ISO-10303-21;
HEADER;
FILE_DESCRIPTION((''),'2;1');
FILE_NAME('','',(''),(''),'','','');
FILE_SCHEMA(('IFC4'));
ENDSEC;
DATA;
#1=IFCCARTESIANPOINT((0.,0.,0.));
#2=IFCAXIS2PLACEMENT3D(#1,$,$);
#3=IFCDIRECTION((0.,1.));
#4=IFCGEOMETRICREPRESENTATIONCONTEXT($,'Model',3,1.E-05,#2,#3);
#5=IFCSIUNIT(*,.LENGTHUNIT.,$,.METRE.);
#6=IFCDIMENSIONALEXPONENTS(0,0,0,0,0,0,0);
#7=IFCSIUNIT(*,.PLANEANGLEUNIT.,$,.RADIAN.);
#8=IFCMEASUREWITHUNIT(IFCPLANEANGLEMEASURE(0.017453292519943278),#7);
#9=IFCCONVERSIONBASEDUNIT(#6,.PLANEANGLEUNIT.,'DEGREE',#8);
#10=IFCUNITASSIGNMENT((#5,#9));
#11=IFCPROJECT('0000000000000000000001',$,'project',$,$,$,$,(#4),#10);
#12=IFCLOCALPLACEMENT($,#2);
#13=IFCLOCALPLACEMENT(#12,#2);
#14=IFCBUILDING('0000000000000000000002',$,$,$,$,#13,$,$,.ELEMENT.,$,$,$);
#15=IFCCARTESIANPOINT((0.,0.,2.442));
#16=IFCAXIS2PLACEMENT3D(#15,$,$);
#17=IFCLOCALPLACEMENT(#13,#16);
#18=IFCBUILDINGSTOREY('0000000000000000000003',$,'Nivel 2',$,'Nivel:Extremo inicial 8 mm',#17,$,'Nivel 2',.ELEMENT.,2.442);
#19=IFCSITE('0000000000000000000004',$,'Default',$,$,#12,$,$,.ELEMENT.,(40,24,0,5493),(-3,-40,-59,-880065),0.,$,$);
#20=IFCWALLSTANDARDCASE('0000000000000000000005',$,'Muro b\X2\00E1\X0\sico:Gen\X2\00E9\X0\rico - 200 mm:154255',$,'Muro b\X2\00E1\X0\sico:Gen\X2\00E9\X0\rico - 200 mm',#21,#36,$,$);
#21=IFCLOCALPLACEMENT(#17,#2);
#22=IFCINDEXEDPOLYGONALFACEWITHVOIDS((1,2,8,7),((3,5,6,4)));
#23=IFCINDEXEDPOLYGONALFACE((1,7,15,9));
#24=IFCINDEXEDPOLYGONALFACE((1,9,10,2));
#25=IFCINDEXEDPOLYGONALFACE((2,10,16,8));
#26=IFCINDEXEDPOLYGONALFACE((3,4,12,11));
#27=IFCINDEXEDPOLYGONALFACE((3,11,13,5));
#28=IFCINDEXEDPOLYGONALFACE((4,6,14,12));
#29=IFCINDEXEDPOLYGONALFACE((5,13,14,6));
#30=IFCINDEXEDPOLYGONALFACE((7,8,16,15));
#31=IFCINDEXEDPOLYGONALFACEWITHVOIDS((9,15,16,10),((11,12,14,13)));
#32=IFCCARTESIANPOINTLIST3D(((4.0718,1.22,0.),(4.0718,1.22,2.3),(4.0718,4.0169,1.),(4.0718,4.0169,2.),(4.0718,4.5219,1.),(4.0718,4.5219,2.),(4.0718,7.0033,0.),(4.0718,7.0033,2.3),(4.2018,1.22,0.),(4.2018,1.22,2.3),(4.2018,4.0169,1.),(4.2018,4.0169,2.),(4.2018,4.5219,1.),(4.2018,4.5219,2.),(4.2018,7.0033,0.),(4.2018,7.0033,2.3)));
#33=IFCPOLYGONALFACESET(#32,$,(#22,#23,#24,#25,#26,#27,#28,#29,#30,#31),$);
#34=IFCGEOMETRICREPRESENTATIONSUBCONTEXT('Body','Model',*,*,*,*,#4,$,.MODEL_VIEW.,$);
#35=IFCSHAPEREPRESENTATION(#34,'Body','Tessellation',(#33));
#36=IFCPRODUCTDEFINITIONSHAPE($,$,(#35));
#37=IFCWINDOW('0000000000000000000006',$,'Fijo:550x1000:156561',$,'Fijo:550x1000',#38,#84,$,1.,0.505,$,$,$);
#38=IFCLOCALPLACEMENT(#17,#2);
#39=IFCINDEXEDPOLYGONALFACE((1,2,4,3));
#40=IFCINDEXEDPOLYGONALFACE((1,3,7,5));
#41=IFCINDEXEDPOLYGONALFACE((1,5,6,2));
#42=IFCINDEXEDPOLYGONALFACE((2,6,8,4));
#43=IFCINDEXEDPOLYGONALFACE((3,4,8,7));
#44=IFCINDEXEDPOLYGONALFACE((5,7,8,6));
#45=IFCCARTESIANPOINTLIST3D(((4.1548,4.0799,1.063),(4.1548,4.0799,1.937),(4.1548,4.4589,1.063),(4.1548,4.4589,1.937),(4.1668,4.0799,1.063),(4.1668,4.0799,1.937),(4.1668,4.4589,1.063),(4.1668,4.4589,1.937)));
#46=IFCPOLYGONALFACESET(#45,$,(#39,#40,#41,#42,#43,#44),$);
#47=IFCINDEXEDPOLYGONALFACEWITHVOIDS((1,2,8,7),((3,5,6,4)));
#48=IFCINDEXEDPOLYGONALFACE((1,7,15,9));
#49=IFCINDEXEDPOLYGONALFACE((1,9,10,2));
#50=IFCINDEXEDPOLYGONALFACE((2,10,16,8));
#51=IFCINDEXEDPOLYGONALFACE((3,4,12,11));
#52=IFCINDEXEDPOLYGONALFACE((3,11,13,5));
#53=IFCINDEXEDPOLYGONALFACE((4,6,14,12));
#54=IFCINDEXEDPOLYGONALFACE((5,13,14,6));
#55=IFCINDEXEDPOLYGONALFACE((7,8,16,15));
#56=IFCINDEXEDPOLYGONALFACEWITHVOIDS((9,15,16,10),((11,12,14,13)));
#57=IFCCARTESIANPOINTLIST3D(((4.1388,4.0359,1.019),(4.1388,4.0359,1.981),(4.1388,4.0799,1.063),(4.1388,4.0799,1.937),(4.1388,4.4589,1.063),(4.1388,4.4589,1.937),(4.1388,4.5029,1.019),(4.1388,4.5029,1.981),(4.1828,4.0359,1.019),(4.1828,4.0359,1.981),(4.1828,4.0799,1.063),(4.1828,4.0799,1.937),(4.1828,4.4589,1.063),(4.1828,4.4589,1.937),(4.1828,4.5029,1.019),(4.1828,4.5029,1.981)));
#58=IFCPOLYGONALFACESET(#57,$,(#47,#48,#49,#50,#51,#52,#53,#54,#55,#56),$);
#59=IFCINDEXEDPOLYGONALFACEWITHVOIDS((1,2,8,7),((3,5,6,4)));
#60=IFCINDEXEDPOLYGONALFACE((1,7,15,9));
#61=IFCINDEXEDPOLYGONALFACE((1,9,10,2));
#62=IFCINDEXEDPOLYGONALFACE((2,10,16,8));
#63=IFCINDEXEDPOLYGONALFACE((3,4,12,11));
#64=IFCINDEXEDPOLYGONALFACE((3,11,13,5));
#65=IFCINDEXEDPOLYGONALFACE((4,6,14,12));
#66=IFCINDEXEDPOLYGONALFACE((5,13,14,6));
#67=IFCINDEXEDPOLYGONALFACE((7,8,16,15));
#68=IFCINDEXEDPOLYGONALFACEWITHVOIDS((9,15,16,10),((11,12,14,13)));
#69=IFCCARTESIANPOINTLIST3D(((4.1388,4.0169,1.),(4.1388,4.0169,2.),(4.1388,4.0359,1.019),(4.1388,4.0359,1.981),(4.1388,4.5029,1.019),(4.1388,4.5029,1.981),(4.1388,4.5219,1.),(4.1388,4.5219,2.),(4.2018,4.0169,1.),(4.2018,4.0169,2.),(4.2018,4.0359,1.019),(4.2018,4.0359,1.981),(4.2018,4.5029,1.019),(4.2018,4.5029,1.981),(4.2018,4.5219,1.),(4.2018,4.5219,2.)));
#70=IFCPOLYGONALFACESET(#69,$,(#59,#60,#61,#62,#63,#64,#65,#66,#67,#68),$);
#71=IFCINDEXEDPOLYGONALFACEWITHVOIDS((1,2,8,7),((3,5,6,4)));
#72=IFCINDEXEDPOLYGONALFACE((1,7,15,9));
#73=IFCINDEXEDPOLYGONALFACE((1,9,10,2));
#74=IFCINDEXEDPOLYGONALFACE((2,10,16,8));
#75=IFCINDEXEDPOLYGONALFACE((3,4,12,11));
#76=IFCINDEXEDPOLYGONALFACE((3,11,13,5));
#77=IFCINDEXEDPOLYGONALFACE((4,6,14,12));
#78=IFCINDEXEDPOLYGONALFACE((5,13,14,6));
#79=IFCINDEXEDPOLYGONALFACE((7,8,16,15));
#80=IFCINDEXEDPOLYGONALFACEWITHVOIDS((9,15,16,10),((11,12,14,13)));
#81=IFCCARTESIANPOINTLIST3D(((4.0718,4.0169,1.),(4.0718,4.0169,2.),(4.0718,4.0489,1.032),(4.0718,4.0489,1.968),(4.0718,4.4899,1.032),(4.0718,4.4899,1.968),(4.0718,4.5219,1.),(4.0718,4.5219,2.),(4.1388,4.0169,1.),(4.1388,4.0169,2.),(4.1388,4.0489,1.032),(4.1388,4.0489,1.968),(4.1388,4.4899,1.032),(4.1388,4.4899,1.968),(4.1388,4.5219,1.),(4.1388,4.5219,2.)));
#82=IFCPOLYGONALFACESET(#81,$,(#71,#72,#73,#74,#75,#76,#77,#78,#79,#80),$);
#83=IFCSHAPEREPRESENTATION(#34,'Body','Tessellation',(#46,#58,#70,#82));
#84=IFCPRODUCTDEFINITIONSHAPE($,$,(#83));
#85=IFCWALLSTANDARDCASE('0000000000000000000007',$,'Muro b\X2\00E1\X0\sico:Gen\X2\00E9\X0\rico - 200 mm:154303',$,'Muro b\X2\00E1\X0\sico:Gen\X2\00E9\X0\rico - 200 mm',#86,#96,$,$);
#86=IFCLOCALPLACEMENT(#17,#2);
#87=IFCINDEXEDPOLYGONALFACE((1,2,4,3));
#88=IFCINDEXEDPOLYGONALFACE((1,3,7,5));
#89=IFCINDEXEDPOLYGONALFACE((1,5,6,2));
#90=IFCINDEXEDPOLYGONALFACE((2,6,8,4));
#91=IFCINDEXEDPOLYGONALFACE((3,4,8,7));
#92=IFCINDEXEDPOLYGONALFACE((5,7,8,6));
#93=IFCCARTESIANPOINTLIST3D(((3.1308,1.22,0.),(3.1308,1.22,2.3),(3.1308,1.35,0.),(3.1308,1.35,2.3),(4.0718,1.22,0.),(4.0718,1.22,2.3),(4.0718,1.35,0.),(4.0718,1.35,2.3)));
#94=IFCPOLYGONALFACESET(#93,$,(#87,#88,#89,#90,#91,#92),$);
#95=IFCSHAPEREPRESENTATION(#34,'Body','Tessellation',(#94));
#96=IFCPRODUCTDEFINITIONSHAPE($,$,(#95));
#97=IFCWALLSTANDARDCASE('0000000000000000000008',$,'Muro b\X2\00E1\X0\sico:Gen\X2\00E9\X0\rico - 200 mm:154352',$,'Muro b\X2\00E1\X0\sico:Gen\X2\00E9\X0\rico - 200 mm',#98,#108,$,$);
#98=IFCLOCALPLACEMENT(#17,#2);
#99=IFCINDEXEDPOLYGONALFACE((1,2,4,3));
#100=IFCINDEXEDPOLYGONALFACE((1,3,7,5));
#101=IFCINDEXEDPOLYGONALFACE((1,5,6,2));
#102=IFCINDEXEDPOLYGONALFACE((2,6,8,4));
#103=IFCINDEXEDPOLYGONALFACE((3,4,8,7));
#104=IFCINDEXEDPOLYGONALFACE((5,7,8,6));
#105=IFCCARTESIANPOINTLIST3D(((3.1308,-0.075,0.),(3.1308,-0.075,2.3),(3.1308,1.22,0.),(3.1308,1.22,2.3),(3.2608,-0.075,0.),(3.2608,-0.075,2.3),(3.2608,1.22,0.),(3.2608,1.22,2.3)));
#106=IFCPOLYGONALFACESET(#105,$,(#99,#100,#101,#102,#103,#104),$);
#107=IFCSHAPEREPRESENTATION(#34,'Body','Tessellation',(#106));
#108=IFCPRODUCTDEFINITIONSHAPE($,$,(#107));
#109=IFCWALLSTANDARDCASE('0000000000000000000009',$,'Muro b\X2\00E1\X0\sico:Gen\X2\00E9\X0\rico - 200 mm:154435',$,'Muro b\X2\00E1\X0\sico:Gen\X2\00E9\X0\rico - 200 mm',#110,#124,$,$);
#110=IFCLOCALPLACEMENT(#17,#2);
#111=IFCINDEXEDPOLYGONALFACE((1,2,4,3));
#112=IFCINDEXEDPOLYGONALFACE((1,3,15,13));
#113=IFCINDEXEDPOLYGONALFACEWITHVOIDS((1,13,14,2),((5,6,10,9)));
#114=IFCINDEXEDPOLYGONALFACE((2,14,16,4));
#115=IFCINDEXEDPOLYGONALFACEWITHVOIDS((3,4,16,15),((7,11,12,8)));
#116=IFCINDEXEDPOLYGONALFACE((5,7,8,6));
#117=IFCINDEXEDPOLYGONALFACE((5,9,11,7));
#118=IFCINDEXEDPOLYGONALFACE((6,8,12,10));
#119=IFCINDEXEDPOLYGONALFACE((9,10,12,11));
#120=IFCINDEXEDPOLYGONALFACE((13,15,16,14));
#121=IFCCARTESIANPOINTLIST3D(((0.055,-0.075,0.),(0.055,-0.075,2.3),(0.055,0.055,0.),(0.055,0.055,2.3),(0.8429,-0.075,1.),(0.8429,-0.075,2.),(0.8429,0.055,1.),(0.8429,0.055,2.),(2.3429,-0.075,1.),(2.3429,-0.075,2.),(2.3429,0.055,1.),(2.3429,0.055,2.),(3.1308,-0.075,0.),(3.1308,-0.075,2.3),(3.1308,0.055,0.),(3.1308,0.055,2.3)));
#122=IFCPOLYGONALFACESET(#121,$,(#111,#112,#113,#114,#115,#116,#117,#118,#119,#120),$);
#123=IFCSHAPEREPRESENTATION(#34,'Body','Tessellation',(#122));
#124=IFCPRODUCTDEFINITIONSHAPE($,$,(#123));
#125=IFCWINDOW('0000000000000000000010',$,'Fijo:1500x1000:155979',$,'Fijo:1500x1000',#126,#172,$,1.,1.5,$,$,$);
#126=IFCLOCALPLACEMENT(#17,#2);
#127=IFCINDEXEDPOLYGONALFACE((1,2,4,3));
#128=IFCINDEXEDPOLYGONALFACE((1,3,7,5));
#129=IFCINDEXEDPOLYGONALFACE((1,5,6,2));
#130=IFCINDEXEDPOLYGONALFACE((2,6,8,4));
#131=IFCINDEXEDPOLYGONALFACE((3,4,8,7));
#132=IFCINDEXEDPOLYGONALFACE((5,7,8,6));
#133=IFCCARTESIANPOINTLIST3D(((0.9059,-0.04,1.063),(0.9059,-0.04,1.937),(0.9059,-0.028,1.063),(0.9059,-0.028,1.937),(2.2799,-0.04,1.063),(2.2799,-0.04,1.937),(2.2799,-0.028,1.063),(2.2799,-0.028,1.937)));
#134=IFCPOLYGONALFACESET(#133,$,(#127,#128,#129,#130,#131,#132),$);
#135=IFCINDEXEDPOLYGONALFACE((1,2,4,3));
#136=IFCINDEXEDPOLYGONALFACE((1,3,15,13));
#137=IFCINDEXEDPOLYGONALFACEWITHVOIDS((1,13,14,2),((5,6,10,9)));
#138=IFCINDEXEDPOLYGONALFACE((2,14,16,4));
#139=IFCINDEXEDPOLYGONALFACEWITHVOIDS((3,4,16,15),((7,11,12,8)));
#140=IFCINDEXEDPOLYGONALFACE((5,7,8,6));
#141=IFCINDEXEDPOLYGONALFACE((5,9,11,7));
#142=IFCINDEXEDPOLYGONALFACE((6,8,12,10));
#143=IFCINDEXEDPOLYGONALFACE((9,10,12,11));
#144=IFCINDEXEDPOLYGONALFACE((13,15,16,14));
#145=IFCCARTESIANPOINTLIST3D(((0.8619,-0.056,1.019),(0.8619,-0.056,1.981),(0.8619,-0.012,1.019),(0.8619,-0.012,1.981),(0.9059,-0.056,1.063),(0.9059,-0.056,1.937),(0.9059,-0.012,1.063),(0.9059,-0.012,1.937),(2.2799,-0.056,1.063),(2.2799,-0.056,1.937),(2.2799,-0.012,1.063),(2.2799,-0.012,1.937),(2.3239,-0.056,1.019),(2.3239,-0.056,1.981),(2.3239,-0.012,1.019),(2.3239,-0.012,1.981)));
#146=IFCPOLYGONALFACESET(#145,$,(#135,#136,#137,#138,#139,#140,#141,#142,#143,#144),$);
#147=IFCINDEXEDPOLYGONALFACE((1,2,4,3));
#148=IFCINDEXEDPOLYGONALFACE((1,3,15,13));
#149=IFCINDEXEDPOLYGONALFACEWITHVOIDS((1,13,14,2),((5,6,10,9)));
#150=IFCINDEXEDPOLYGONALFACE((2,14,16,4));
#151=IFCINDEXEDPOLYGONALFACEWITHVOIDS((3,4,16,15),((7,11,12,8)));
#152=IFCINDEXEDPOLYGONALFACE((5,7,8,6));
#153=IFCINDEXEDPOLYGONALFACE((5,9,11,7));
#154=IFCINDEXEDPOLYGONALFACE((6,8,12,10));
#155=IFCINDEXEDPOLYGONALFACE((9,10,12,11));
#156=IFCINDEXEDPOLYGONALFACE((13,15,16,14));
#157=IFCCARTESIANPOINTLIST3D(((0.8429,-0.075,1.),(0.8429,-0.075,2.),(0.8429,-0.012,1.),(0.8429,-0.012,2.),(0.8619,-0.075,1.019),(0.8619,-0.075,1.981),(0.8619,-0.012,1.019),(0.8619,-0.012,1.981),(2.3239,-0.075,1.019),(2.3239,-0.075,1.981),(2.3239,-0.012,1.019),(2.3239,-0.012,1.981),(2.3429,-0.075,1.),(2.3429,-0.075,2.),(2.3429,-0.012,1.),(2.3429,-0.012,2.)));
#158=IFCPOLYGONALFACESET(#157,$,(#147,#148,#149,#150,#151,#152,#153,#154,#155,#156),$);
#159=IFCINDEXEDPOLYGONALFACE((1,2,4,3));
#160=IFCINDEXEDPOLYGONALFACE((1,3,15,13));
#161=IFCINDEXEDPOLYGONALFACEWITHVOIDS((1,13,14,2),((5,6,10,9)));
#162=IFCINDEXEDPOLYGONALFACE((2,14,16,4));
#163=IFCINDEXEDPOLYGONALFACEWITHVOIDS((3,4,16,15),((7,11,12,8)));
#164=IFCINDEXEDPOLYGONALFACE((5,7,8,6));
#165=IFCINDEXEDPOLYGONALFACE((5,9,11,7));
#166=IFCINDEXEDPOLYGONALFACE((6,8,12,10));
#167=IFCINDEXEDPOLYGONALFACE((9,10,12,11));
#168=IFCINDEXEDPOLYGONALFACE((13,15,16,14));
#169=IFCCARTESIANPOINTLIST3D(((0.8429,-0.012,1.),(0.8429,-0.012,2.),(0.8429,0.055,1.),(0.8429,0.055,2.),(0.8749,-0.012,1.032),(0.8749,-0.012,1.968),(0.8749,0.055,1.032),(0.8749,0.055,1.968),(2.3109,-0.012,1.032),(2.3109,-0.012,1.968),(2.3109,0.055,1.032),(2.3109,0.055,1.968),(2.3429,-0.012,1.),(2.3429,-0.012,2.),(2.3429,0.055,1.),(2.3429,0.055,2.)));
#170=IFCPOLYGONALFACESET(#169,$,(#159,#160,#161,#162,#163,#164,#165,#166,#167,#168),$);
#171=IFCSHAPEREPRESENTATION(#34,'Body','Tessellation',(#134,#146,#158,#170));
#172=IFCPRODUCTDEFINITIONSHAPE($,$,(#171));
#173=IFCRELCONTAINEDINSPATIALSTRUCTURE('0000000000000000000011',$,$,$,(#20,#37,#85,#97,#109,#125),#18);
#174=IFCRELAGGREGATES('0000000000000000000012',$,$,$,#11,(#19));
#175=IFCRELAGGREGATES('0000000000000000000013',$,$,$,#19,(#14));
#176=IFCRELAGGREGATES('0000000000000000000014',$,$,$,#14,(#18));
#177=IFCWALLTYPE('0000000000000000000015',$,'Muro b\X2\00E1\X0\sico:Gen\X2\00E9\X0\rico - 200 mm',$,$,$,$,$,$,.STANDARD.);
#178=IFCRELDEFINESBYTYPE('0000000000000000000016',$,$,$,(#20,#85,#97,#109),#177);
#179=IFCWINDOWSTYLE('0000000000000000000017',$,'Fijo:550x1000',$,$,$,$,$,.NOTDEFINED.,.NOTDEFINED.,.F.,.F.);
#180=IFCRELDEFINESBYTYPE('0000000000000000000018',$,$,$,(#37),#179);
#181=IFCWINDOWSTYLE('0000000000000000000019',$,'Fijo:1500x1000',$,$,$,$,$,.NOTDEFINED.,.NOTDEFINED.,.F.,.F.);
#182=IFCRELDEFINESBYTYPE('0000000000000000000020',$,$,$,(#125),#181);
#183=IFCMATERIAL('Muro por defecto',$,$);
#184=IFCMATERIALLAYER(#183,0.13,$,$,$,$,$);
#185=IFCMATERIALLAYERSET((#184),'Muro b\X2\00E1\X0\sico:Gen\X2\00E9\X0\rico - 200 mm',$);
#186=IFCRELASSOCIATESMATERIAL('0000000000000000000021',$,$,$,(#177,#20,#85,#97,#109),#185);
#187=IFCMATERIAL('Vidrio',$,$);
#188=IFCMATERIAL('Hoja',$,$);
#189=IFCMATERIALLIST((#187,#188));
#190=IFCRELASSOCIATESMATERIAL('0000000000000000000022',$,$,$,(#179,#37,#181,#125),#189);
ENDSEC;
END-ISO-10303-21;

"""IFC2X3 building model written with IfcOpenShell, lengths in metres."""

from ifc_helpers import new_model, entity, si_unit, converted_unit, direction, frame, frame_2d, origin, origin_2d_with_axis, place, context, subcontext, project, spatial, polyline, rectangle, outline, extrude, source, transform, mapped, material, material_list, layer, layer_set, layer_usage, type_object, type_shapes, element, fill, save


model = new_model("IFC2X3")

# Units and contexts
model_context = context("Model", 3, precision=1e-05, world=origin(), true_north=direction((0.0, 1.0)))
body_context = subcontext(model_context, "Body", "Model", "MODEL_VIEW")
ifc_project = project(units=[si_unit("LENGTHUNIT", "METRE"), converted_unit("PLANEANGLEUNIT", "DEGREE", entity("IfcPlaneAngleMeasure", 0.017453292519943278), si_unit("PLANEANGLEUNIT", "RADIAN"), dimensions=[0, 0, 0, 0, 0, 0, 0])], contexts=[model_context])

# Site, building, storey
site_placement = place(None, origin())
site = spatial("IfcSite", under=ifc_project, at=site_placement, Name="Default", CompositionType="ELEMENT", RefLatitude=(40, 24, 0, 5493), RefLongitude=(-3, -40, -59, -880065), RefElevation=0.0)
building_placement = place(site_placement, origin())
building = spatial("IfcBuilding", under=site, at=building_placement, CompositionType="ELEMENT")
storey_placement = place(building_placement, frame((0.0, 0.0, 2.442)))
storey = spatial("IfcBuildingStorey", under=building, at=storey_placement, Name="Nivel 2", ObjectType="Nivel:Extremo inicial 8 mm", LongName="Nivel 2", CompositionType="ELEMENT", Elevation=2.442)

# Shared definitions
ifc_material_1 = material(Name="Muro por defecto")
ifc_layer_1 = layer(ifc_material_1, 0.13)
ifc_layer_set_1 = layer_set([ifc_layer_1], Name="Muro básico:Genérico - 200 mm")
wall_type_1 = type_object("IfcWallType", Name="Muro básico:Genérico - 200 mm", PredefinedType="STANDARD", material=ifc_layer_set_1)

# Shared definitions
ifc_material_2 = material(Name="Vidrio")
ifc_material_3 = material(Name="Hoja")
ifc_material_list_1 = material_list([ifc_material_2, ifc_material_3])
window_style_1 = type_object("IfcWindowStyle", Name="Fijo:550x1000", ConstructionType="NOTDEFINED", OperationType="NOTDEFINED", ParameterTakesPrecedence=False, Sizeable=False, material=ifc_material_list_1)
shared_shape_1 = source(origin(), body_context, "Body", "SweptSolid", [
    extrude(rectangle(XDim=0.012, YDim=0.379, at=origin_2d_with_axis()), frame((0.2525, 0.089, 0.063), z_axis=(0.0, 0.0, 1.0), x_axis=(0.0, -1.0, 0.0)), (0.0, 0.0, 1.0), 0.874),
    extrude(outline(polyline([(-0.2335, -0.481), (0.2335, -0.481), (0.2335, 0.481), (-0.2335, 0.481), (-0.2335, -0.481)]), holes=[polyline([(-0.1895, -0.437), (-0.1895, 0.437), (0.1895, 0.437), (0.1895, -0.437), (-0.1895, -0.437)])]), frame((0.2525, 0.067, 0.5), z_axis=(0.0, 1.0, 0.0), x_axis=(1.0, 0.0, 0.0)), (0.0, 0.0, 1.0), 0.044),
    extrude(outline(polyline([(-0.2525, -0.5), (0.2525, -0.5), (0.2525, 0.5), (-0.2525, 0.5), (-0.2525, -0.5)]), holes=[polyline([(-0.2335, -0.481), (-0.2335, 0.481), (0.2335, 0.481), (0.2335, -0.481), (-0.2335, -0.481)])]), frame((0.2525, 0.067, 0.5), z_axis=(0.0, 1.0, 0.0), x_axis=(1.0, 0.0, 0.0)), (0.0, 0.0, 1.0), 0.063),
    extrude(outline(polyline([(-0.2525, -0.5), (0.2525, -0.5), (0.2525, 0.5), (-0.2525, 0.5), (-0.2525, -0.5)]), holes=[polyline([(-0.2205, -0.468), (-0.2205, 0.468), (0.2205, 0.468), (0.2205, -0.468), (-0.2205, -0.468)])]), frame((0.2525, 0.0, 0.5), z_axis=(0.0, 1.0, 0.0), x_axis=(1.0, 0.0, 0.0)), (0.0, 0.0, 1.0), 0.067),
])
type_shapes(window_style_1, [shared_shape_1])

# Wall, opening, window
ifc_layer_usage_1 = layer_usage(ifc_layer_set_1, "AXIS2", "NEGATIVE", 0.065)
wall_1_placement = place(storey_placement, frame((4.1368, 7.0033, 0.0), z_axis=(0.0, 0.0, 1.0), x_axis=(0.0, -1.0, 0.0)))
wall_1 = element("IfcWallStandardCase", 1, at=wall_1_placement, inside=storey, type_object=wall_type_1, material=ifc_layer_usage_1, Name="Muro básico:Genérico - 200 mm:154255", ObjectType="Muro básico:Genérico - 200 mm", context=body_context, shape_type="SweptSolid", body=[
    extrude(rectangle(XDim=5.7833, YDim=0.13, at=frame_2d((2.8917, 0.0), x_axis=(-1.0, 0.0))), origin(), (0.0, 0.0, 1.0), 2.3),
])
opening_1_placement = place(wall_1_placement, frame((2.4814, -0.065, 1.0)))
opening_1 = element("IfcOpeningElement", 2, at=opening_1_placement, cuts=wall_1, ObjectType="Opening", context=body_context, shape_type="SweptSolid", body=[
    extrude(rectangle(XDim=1.0, YDim=0.505, at=frame_2d((0.5, 0.2525), x_axis=(1.0, 0.0))), frame((0.0, 0.0, 0.0), z_axis=(0.0, 1.0, 0.0), x_axis=(0.0, 0.0, 1.0)), (0.0, 0.0, 1.0), 0.13),
])
window_1_placement = place(opening_1_placement, origin())
window_1 = element("IfcWindow", 3, at=window_1_placement, inside=storey, type_object=window_style_1, material=ifc_material_list_1, Name="Fijo:550x1000:156561", ObjectType="Fijo:550x1000", OverallHeight=1.0, OverallWidth=0.505, context=body_context, shape_type="MappedRepresentation", body=[
    mapped(shared_shape_1, transform((0.0, 0.0, 0.0), scale=1.0)),
])
fill(opening_1, window_1)

# Walls
ifc_layer_usage_2 = layer_usage(ifc_layer_set_1, "AXIS2", "NEGATIVE", 0.065)
wall_2_placement = place(storey_placement, frame((4.0718, 1.285, 0.0), z_axis=(0.0, 0.0, 1.0), x_axis=(-1.0, 0.0, 0.0)))
element("IfcWallStandardCase", 4, at=wall_2_placement, inside=storey, type_object=wall_type_1, material=ifc_layer_usage_2, Name="Muro básico:Genérico - 200 mm:154303", ObjectType="Muro básico:Genérico - 200 mm", context=body_context, shape_type="SweptSolid", body=[
    extrude(rectangle(XDim=0.941, YDim=0.13, at=frame_2d((0.4705, 0.0), x_axis=(-1.0, 0.0))), origin(), (0.0, 0.0, 1.0), 2.3),
])
ifc_layer_usage_3 = layer_usage(ifc_layer_set_1, "AXIS2", "NEGATIVE", 0.065)
wall_3_placement = place(storey_placement, frame((3.1958, 1.22, 0.0), z_axis=(0.0, 0.0, 1.0), x_axis=(0.0, -1.0, 0.0)))
element("IfcWallStandardCase", 5, at=wall_3_placement, inside=storey, type_object=wall_type_1, material=ifc_layer_usage_3, Name="Muro básico:Genérico - 200 mm:154352", ObjectType="Muro básico:Genérico - 200 mm", context=body_context, shape_type="SweptSolid", body=[
    extrude(rectangle(XDim=1.295, YDim=0.13, at=frame_2d((0.6475, 0.0), x_axis=(-1.0, 0.0))), origin(), (0.0, 0.0, 1.0), 2.3),
])

# Wall, opening, window
ifc_layer_usage_4 = layer_usage(ifc_layer_set_1, "AXIS2", "NEGATIVE", 0.065)
wall_4_placement = place(storey_placement, frame((3.1308, -0.01, 0.0), z_axis=(0.0, 0.0, 1.0), x_axis=(-1.0, 0.0, 0.0)))
wall_4 = element("IfcWallStandardCase", 6, at=wall_4_placement, inside=storey, type_object=wall_type_1, material=ifc_layer_usage_4, Name="Muro básico:Genérico - 200 mm:154435", ObjectType="Muro básico:Genérico - 200 mm", context=body_context, shape_type="SweptSolid", body=[
    extrude(rectangle(XDim=3.0758, YDim=0.13, at=frame_2d((1.5379, 0.0), x_axis=(-1.0, 0.0))), origin(), (0.0, 0.0, 1.0), 2.3),
])
opening_2_placement = place(wall_4_placement, frame((0.7879, -0.065, 1.0)))
opening_2 = element("IfcOpeningElement", 7, at=opening_2_placement, cuts=wall_4, ObjectType="Opening", context=body_context, shape_type="SweptSolid", body=[
    extrude(rectangle(XDim=1.0, YDim=1.5, at=frame_2d((0.5, 0.75), x_axis=(1.0, 0.0))), frame((0.0, 0.0, 0.0), z_axis=(0.0, 1.0, 0.0), x_axis=(0.0, 0.0, 1.0)), (0.0, 0.0, 1.0), 0.13),
])
window_style_2 = type_object("IfcWindowStyle", Name="Fijo:1500x1000", ConstructionType="NOTDEFINED", OperationType="NOTDEFINED", ParameterTakesPrecedence=False, Sizeable=False, material=ifc_material_list_1)
shared_shape_2 = source(origin(), body_context, "Body", "SweptSolid", [
    extrude(rectangle(XDim=0.012, YDim=1.374, at=origin_2d_with_axis()), frame((0.75, 0.089, 0.063), z_axis=(0.0, 0.0, 1.0), x_axis=(0.0, -1.0, 0.0)), (0.0, 0.0, 1.0), 0.874),
    extrude(outline(polyline([(-0.731, -0.481), (0.731, -0.481), (0.731, 0.481), (-0.731, 0.481), (-0.731, -0.481)]), holes=[polyline([(-0.687, -0.437), (-0.687, 0.437), (0.687, 0.437), (0.687, -0.437), (-0.687, -0.437)])]), frame((0.75, 0.067, 0.5), z_axis=(0.0, 1.0, 0.0), x_axis=(1.0, 0.0, 0.0)), (0.0, 0.0, 1.0), 0.044),
    extrude(outline(polyline([(-0.75, -0.5), (0.75, -0.5), (0.75, 0.5), (-0.75, 0.5), (-0.75, -0.5)]), holes=[polyline([(-0.731, -0.481), (-0.731, 0.481), (0.731, 0.481), (0.731, -0.481), (-0.731, -0.481)])]), frame((0.75, 0.067, 0.5), z_axis=(0.0, 1.0, 0.0), x_axis=(1.0, 0.0, 0.0)), (0.0, 0.0, 1.0), 0.063),
    extrude(outline(polyline([(-0.75, -0.5), (0.75, -0.5), (0.75, 0.5), (-0.75, 0.5), (-0.75, -0.5)]), holes=[polyline([(-0.718, -0.468), (-0.718, 0.468), (0.718, 0.468), (0.718, -0.468), (-0.718, -0.468)])]), frame((0.75, 0.0, 0.5), z_axis=(0.0, 1.0, 0.0), x_axis=(1.0, 0.0, 0.0)), (0.0, 0.0, 1.0), 0.067),
])
type_shapes(window_style_2, [shared_shape_2])
window_2_placement = place(opening_2_placement, origin())
window_2 = element("IfcWindow", 8, at=window_2_placement, inside=storey, type_object=window_style_2, material=ifc_material_list_1, Name="Fijo:1500x1000:155979", ObjectType="Fijo:1500x1000", OverallHeight=1.0, OverallWidth=1.5, context=body_context, shape_type="MappedRepresentation", body=[
    mapped(shared_shape_2, transform((0.0, 0.0, 0.0), scale=1.0)),
])
fill(opening_2, window_2)

save(model, "model.ifc")
